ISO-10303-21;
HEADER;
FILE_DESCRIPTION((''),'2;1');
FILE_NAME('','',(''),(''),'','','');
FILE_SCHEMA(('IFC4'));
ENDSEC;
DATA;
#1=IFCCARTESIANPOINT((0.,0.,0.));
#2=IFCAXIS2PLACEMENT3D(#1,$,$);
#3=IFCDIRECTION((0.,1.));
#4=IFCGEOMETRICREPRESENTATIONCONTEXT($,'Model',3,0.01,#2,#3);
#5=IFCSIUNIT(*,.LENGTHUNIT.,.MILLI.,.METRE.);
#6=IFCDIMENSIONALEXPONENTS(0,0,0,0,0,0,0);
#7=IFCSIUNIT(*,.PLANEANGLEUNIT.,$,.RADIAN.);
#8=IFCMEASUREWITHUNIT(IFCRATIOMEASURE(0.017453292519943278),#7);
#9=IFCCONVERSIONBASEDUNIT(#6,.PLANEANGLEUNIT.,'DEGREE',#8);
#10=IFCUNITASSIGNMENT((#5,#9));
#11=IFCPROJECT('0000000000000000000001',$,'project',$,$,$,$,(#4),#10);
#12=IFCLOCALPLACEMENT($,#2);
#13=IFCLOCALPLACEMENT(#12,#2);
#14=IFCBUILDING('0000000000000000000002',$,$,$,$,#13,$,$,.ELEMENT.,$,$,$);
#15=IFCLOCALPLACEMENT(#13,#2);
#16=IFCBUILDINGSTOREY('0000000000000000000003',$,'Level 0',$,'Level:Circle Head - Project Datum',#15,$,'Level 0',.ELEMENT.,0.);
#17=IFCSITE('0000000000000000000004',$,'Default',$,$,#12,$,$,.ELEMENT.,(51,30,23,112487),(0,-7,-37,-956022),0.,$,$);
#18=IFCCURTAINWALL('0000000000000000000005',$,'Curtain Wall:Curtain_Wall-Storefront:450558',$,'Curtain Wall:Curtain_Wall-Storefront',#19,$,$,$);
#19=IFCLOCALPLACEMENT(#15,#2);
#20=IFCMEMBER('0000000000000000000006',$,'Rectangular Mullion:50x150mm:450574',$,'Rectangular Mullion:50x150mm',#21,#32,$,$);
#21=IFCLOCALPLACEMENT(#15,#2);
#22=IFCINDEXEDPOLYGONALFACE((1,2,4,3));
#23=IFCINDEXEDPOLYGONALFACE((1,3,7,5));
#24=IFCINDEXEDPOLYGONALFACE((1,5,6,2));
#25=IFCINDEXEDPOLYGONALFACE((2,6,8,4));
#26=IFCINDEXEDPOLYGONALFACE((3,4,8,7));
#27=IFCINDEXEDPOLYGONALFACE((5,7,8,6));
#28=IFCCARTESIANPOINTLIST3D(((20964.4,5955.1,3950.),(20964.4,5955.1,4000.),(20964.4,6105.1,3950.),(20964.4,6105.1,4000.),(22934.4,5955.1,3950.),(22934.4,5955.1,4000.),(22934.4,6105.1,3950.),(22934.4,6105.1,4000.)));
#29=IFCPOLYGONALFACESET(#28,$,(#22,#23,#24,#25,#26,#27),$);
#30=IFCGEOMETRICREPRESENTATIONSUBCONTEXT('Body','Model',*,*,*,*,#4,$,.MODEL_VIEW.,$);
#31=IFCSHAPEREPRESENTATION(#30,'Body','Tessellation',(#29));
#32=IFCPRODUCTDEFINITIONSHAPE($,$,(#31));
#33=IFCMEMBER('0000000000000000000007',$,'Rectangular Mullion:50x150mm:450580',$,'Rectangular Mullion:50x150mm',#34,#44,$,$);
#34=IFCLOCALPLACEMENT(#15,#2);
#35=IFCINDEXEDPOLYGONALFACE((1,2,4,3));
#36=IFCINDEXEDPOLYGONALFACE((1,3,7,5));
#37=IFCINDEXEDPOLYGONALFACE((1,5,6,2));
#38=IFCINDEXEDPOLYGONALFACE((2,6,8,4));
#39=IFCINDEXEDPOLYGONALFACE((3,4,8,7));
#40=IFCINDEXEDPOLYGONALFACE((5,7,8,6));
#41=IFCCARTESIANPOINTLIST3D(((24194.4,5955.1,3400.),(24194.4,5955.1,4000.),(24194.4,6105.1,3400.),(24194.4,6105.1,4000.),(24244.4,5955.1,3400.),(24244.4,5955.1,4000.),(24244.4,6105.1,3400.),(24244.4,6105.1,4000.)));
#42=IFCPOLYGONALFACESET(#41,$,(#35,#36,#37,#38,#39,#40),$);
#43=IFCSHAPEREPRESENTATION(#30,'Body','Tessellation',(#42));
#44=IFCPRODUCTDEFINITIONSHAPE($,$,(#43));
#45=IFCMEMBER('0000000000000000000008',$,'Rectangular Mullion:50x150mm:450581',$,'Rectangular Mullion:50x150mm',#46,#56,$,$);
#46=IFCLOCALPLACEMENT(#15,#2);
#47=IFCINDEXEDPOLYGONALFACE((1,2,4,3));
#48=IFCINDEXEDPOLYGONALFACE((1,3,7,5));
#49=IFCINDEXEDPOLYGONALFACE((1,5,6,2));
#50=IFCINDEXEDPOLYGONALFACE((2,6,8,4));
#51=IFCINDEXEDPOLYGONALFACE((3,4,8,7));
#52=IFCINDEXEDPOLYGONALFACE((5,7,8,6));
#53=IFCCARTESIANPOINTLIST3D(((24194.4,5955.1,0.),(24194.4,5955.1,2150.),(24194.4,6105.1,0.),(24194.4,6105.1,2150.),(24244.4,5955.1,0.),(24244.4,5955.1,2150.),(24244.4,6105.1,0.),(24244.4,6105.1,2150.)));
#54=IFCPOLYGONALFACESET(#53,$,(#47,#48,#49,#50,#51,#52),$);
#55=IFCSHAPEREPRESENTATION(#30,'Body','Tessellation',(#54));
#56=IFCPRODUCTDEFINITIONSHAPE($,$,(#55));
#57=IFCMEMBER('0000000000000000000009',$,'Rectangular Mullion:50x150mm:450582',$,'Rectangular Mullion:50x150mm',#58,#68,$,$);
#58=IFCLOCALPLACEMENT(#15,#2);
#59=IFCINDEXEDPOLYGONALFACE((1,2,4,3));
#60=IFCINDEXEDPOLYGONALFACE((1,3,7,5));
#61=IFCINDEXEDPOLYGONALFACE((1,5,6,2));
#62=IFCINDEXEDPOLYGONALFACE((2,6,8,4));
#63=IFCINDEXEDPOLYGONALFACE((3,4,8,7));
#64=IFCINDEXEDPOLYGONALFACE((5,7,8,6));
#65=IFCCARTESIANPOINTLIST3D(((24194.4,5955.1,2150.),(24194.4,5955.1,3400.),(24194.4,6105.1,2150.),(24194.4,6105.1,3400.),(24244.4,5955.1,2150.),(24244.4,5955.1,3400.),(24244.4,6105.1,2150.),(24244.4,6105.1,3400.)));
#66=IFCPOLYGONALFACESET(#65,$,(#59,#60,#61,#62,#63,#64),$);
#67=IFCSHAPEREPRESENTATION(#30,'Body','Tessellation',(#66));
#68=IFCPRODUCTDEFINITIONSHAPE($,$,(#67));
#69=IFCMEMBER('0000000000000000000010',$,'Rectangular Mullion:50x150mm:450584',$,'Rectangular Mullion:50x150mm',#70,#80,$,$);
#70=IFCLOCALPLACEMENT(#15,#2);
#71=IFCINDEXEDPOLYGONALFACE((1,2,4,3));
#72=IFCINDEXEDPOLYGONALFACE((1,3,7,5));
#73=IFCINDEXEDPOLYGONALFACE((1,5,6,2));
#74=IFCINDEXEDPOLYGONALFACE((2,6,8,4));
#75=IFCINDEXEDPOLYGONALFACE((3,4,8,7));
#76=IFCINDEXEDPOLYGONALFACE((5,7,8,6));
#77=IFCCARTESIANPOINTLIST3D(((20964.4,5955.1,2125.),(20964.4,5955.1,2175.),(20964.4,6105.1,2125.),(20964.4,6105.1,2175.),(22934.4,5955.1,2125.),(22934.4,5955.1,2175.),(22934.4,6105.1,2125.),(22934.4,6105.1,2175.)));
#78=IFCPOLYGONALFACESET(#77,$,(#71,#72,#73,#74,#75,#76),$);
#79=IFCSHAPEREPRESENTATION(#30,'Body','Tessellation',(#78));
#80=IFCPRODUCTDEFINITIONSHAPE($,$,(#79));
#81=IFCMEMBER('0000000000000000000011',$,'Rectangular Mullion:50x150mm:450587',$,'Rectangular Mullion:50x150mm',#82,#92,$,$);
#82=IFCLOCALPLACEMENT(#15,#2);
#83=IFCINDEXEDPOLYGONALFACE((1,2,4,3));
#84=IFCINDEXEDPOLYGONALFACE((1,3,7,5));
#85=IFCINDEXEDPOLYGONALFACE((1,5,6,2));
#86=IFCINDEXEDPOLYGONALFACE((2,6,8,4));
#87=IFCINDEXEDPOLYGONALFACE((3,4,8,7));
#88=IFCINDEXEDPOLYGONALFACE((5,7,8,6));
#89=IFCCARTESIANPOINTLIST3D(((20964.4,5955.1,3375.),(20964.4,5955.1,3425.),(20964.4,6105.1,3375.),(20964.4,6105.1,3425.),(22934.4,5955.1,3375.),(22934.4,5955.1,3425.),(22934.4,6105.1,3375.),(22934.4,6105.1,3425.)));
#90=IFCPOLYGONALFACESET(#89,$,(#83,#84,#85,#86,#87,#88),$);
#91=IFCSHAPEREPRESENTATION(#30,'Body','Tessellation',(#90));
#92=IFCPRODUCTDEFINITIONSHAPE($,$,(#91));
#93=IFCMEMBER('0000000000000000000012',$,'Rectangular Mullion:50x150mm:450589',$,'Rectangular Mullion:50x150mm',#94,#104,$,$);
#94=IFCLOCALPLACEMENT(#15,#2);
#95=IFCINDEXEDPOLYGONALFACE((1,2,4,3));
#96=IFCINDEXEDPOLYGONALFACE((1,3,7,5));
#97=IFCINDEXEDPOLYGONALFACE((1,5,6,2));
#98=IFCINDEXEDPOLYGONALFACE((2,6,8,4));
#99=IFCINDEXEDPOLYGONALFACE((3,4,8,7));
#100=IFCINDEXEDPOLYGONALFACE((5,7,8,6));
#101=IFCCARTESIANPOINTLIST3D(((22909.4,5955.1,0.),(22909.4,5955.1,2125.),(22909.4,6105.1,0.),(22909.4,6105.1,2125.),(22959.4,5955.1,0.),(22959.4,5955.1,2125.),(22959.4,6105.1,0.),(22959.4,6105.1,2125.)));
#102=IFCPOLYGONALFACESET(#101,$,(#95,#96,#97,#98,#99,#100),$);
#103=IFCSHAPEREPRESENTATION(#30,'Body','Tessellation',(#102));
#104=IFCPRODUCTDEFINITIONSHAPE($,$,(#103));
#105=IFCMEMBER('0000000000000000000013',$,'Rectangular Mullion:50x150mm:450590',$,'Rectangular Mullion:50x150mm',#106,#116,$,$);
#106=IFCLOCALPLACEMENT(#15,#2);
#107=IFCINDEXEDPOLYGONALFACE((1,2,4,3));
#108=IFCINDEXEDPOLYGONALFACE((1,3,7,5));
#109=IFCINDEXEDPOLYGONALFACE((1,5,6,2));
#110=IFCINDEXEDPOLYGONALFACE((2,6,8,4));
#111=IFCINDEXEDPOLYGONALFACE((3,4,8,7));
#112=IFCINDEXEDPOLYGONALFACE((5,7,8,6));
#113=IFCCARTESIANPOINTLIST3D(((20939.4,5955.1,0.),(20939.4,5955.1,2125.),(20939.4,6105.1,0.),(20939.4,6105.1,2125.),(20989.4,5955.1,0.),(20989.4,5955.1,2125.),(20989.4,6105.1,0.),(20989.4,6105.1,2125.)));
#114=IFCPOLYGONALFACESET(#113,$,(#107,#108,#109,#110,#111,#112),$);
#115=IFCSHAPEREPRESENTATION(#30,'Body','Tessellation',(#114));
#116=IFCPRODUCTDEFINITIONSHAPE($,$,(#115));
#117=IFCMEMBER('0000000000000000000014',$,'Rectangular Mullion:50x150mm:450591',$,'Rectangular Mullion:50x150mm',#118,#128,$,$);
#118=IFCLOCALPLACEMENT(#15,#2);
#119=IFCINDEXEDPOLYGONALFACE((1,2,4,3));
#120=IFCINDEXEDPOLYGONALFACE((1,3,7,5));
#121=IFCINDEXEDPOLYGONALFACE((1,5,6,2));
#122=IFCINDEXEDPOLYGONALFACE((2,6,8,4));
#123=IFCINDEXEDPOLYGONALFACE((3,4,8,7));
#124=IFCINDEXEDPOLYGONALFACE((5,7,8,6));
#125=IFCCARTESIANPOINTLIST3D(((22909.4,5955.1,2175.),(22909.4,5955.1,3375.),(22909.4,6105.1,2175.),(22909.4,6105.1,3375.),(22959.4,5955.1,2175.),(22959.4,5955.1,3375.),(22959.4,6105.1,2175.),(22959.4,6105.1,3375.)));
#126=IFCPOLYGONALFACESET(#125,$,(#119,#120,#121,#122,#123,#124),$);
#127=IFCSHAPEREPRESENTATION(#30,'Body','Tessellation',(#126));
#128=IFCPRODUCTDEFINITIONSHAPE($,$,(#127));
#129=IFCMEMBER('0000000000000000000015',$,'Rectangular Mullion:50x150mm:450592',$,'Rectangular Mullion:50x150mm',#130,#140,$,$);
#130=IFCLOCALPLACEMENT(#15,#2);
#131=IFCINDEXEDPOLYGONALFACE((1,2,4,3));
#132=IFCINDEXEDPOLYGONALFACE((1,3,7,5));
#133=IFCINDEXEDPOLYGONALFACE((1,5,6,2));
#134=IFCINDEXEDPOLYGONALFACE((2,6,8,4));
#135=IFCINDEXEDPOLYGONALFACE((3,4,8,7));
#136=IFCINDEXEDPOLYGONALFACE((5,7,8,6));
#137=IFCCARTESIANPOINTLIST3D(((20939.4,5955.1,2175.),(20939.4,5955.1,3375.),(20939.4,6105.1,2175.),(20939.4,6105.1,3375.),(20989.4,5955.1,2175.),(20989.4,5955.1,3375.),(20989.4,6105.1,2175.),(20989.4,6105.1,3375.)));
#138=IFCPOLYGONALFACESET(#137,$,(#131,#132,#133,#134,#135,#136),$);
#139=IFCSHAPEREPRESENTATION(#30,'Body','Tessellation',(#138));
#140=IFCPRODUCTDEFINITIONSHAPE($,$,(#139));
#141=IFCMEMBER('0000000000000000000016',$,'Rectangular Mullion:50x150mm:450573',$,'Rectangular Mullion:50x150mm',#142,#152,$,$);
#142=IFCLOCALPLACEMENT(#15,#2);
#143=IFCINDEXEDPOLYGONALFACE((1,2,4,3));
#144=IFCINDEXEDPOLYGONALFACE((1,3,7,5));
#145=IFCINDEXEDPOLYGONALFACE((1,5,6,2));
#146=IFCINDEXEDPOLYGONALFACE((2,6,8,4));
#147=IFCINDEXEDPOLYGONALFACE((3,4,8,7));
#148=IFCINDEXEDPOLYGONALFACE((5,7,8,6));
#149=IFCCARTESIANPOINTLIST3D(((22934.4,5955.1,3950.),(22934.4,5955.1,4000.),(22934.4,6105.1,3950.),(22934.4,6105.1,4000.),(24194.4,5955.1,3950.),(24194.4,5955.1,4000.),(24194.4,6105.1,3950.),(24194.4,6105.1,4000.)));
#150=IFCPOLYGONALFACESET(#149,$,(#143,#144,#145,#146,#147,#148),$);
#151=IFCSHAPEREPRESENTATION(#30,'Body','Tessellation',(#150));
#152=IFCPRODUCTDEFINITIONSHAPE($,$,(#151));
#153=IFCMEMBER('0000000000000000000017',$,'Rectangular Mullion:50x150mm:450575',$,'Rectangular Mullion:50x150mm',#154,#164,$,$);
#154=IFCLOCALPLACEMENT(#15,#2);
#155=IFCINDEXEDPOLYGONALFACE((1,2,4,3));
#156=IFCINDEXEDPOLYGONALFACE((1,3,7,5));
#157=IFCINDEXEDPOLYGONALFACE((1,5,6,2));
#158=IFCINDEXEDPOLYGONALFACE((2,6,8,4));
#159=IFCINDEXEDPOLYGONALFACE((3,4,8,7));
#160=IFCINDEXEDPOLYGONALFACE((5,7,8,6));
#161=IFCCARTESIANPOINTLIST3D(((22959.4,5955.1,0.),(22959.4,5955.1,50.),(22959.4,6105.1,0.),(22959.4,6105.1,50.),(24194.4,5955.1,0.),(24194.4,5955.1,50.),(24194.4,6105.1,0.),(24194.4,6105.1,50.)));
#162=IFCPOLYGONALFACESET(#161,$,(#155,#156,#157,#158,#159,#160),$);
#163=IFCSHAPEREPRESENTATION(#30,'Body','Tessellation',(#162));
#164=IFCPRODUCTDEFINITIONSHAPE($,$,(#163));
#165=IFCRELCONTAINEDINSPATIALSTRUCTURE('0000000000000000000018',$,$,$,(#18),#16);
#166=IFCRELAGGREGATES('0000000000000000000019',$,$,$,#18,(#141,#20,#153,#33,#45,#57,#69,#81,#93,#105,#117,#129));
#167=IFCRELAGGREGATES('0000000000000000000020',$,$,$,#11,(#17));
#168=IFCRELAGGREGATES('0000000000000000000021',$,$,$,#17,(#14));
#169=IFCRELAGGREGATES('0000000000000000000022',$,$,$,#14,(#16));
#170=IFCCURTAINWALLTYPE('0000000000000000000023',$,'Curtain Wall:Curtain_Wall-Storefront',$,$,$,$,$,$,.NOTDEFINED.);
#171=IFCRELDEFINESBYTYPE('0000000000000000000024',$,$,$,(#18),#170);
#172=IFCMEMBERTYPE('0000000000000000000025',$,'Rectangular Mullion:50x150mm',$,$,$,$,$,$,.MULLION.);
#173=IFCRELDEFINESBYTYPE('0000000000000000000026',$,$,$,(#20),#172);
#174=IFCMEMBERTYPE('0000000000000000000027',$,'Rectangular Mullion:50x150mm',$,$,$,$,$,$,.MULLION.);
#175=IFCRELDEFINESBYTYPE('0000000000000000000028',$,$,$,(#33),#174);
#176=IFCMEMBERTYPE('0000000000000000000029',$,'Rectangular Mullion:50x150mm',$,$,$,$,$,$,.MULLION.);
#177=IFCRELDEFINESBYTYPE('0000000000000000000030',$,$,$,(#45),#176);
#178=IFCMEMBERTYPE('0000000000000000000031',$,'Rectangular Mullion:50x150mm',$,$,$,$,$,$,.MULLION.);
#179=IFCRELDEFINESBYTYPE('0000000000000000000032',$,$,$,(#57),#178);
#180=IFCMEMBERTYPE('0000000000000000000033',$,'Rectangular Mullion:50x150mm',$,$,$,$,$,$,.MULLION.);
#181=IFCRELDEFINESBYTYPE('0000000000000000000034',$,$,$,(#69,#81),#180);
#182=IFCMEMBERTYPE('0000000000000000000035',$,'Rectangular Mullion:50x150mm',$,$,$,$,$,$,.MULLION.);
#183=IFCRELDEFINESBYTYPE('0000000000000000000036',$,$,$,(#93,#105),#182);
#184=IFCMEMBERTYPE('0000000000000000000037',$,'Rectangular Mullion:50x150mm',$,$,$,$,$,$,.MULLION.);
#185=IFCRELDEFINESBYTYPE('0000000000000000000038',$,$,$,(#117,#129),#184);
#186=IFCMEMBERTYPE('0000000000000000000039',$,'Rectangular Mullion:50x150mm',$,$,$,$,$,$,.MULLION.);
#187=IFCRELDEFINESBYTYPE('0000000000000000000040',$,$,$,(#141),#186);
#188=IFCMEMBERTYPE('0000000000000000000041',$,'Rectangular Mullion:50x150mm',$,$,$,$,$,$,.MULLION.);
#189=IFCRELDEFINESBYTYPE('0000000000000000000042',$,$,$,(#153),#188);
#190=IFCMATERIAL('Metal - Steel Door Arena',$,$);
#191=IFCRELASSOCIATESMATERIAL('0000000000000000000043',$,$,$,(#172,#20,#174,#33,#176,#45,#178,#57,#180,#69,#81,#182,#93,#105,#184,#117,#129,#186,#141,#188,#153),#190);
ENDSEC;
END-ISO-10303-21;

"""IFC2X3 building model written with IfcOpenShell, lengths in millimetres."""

from ifc_helpers import new_model, entity, si_unit, converted_unit, direction, frame, origin, origin_2d_with_axis, place, context, subcontext, project, spatial, rectangle, extrude, source, transform, mapped, material, type_object, type_shapes, element, aggregate, save


model = new_model("IFC2X3")

# Units and contexts
model_context = context("Model", 3, precision=0.01, world=origin(), true_north=direction((0.0, 1.0)))
body_context = subcontext(model_context, "Body", "Model", "MODEL_VIEW")
ifc_project = project(units=[si_unit("LENGTHUNIT", "METRE", prefix="MILLI"), converted_unit("PLANEANGLEUNIT", "DEGREE", entity("IfcRatioMeasure", 0.017453292519943278), si_unit("PLANEANGLEUNIT", "RADIAN"), dimensions=[0, 0, 0, 0, 0, 0, 0])], contexts=[model_context])

# Site, building, storey
site_placement = place(None, origin())
site = spatial("IfcSite", under=ifc_project, at=site_placement, Name="Default", CompositionType="ELEMENT", RefLatitude=(51, 30, 23, 112487), RefLongitude=(0, -7, -37, -956022), RefElevation=0.0)
building_placement = place(site_placement, origin())
building = spatial("IfcBuilding", under=site, at=building_placement, CompositionType="ELEMENT")
storey_placement = place(building_placement, origin())
storey = spatial("IfcBuildingStorey", under=building, at=storey_placement, Name="Level 0", ObjectType="Level:Circle Head - Project Datum", LongName="Level 0", CompositionType="ELEMENT", Elevation=0.0)

# Curtain wall, members
curtain_wall_type = type_object("IfcCurtainWallType", Name="Curtain Wall:Curtain_Wall-Storefront", PredefinedType="NOTDEFINED")
curtain_wall_placement = place(storey_placement, origin())
curtain_wall = element("IfcCurtainWall", 1, at=curtain_wall_placement, inside=storey, type_object=curtain_wall_type, Name="Curtain Wall:Curtain_Wall-Storefront:450558", ObjectType="Curtain Wall:Curtain_Wall-Storefront")
ifc_material_1 = material(Name="Metal - Steel Door Arena")
member_type_1 = type_object("IfcMemberType", Name="Rectangular Mullion:50x150mm", PredefinedType="MULLION", material=ifc_material_1)
shared_shape_1 = source(origin(), body_context, "Body", "SweptSolid", [
    extrude(rectangle(XDim=150.0, YDim=50.0, at=origin_2d_with_axis()), frame((-25.0, 0.0, -1970.0), z_axis=(0.0, 0.0, 1.0), x_axis=(0.0, -1.0, 0.0)), (0.0, 0.0, 1.0), 1970.0),
])
type_shapes(member_type_1, [shared_shape_1])
member_1_placement = place(curtain_wall_placement, frame((20964.4, 6030.1, 4000.0), z_axis=(-1.0, 0.0, 0.0), x_axis=(0.0, 0.0, 1.0)))
member_1 = element("IfcMember", 2, at=member_1_placement, type_object=member_type_1, material=ifc_material_1, Name="Rectangular Mullion:50x150mm:450574", ObjectType="Rectangular Mullion:50x150mm", context=body_context, shape_type="MappedRepresentation", body=[
    mapped(shared_shape_1, transform((0.0, 0.0, 0.0), scale=1.0)),
])
member_type_2 = type_object("IfcMemberType", Name="Rectangular Mullion:50x150mm", PredefinedType="MULLION", material=ifc_material_1)
shared_shape_2 = source(origin(), body_context, "Body", "SweptSolid", [
    extrude(rectangle(XDim=150.0, YDim=50.0, at=origin_2d_with_axis()), frame((-25.0, 0.0, -600.0), z_axis=(0.0, 0.0, 1.0), x_axis=(0.0, -1.0, 0.0)), (0.0, 0.0, 1.0), 600.0),
])
type_shapes(member_type_2, [shared_shape_2])
member_2_placement = place(curtain_wall_placement, frame((24244.4, 6030.1, 4000.0)))
member_2 = element("IfcMember", 3, at=member_2_placement, type_object=member_type_2, material=ifc_material_1, Name="Rectangular Mullion:50x150mm:450580", ObjectType="Rectangular Mullion:50x150mm", context=body_context, shape_type="MappedRepresentation", body=[
    mapped(shared_shape_2, transform((0.0, 0.0, 0.0), scale=1.0)),
])
member_type_3 = type_object("IfcMemberType", Name="Rectangular Mullion:50x150mm", PredefinedType="MULLION", material=ifc_material_1)
shared_shape_3 = source(origin(), body_context, "Body", "SweptSolid", [
    extrude(rectangle(XDim=150.0, YDim=50.0, at=origin_2d_with_axis()), frame((-25.0, 0.0, -2150.0), z_axis=(0.0, 0.0, 1.0), x_axis=(0.0, -1.0, 0.0)), (0.0, 0.0, 1.0), 2150.0),
])
type_shapes(member_type_3, [shared_shape_3])
member_3_placement = place(curtain_wall_placement, frame((24244.4, 6030.1, 2150.0)))
member_3 = element("IfcMember", 4, at=member_3_placement, type_object=member_type_3, material=ifc_material_1, Name="Rectangular Mullion:50x150mm:450581", ObjectType="Rectangular Mullion:50x150mm", context=body_context, shape_type="MappedRepresentation", body=[
    mapped(shared_shape_3, transform((0.0, 0.0, 0.0), scale=1.0)),
])
member_type_4 = type_object("IfcMemberType", Name="Rectangular Mullion:50x150mm", PredefinedType="MULLION", material=ifc_material_1)
shared_shape_4 = source(origin(), body_context, "Body", "SweptSolid", [
    extrude(rectangle(XDim=150.0, YDim=50.0, at=origin_2d_with_axis()), frame((-25.0, 0.0, -1250.0), z_axis=(0.0, 0.0, 1.0), x_axis=(0.0, -1.0, 0.0)), (0.0, 0.0, 1.0), 1250.0),
])
type_shapes(member_type_4, [shared_shape_4])
member_4_placement = place(curtain_wall_placement, frame((24244.4, 6030.1, 3400.0)))
member_4 = element("IfcMember", 5, at=member_4_placement, type_object=member_type_4, material=ifc_material_1, Name="Rectangular Mullion:50x150mm:450582", ObjectType="Rectangular Mullion:50x150mm", context=body_context, shape_type="MappedRepresentation", body=[
    mapped(shared_shape_4, transform((0.0, 0.0, 0.0), scale=1.0)),
])
member_type_5 = type_object("IfcMemberType", Name="Rectangular Mullion:50x150mm", PredefinedType="MULLION", material=ifc_material_1)
shared_shape_5 = source(origin(), body_context, "Body", "SweptSolid", [
    extrude(rectangle(XDim=150.0, YDim=50.0, at=origin_2d_with_axis()), frame((0.0, 0.0, -1970.0), z_axis=(0.0, 0.0, 1.0), x_axis=(0.0, -1.0, 0.0)), (0.0, 0.0, 1.0), 1970.0),
])
type_shapes(member_type_5, [shared_shape_5])
member_5_placement = place(curtain_wall_placement, frame((20964.4, 6030.1, 2150.0), z_axis=(-1.0, 0.0, 0.0), x_axis=(0.0, 0.0, 1.0)))
member_5 = element("IfcMember", 6, at=member_5_placement, type_object=member_type_5, material=ifc_material_1, Name="Rectangular Mullion:50x150mm:450584", ObjectType="Rectangular Mullion:50x150mm", context=body_context, shape_type="MappedRepresentation", body=[
    mapped(shared_shape_5, transform((0.0, 0.0, 0.0), scale=1.0)),
])
member_6_placement = place(curtain_wall_placement, frame((20964.4, 6030.1, 3400.0), z_axis=(-1.0, 0.0, 0.0), x_axis=(0.0, 0.0, 1.0)))
member_6 = element("IfcMember", 7, at=member_6_placement, type_object=member_type_5, material=ifc_material_1, Name="Rectangular Mullion:50x150mm:450587", ObjectType="Rectangular Mullion:50x150mm", context=body_context, shape_type="MappedRepresentation", body=[
    mapped(shared_shape_5, transform((0.0, 0.0, 0.0), scale=1.0)),
])
member_type_6 = type_object("IfcMemberType", Name="Rectangular Mullion:50x150mm", PredefinedType="MULLION", material=ifc_material_1)
shared_shape_6 = source(origin(), body_context, "Body", "SweptSolid", [
    extrude(rectangle(XDim=150.0, YDim=50.0, at=origin_2d_with_axis()), frame((0.0, 0.0, -2125.0), z_axis=(0.0, 0.0, 1.0), x_axis=(0.0, -1.0, 0.0)), (0.0, 0.0, 1.0), 2125.0),
])
type_shapes(member_type_6, [shared_shape_6])
member_7_placement = place(curtain_wall_placement, frame((22934.4, 6030.1, 0.0), z_axis=(0.0, 0.0, -1.0), x_axis=(-1.0, 0.0, 0.0)))
member_7 = element("IfcMember", 8, at=member_7_placement, type_object=member_type_6, material=ifc_material_1, Name="Rectangular Mullion:50x150mm:450589", ObjectType="Rectangular Mullion:50x150mm", context=body_context, shape_type="MappedRepresentation", body=[
    mapped(shared_shape_6, transform((0.0, 0.0, 0.0), scale=1.0)),
])
member_8_placement = place(curtain_wall_placement, frame((20964.4, 6030.1, 0.0), z_axis=(0.0, 0.0, -1.0), x_axis=(-1.0, 0.0, 0.0)))
member_8 = element("IfcMember", 9, at=member_8_placement, type_object=member_type_6, material=ifc_material_1, Name="Rectangular Mullion:50x150mm:450590", ObjectType="Rectangular Mullion:50x150mm", context=body_context, shape_type="MappedRepresentation", body=[
    mapped(shared_shape_6, transform((0.0, 0.0, 0.0), scale=1.0)),
])
member_type_7 = type_object("IfcMemberType", Name="Rectangular Mullion:50x150mm", PredefinedType="MULLION", material=ifc_material_1)
shared_shape_7 = source(origin(), body_context, "Body", "SweptSolid", [
    extrude(rectangle(XDim=150.0, YDim=50.0, at=origin_2d_with_axis()), frame((0.0, 0.0, -1200.0), z_axis=(0.0, 0.0, 1.0), x_axis=(0.0, -1.0, 0.0)), (0.0, 0.0, 1.0), 1200.0),
])
type_shapes(member_type_7, [shared_shape_7])
member_9_placement = place(curtain_wall_placement, frame((22934.4, 6030.1, 2175.0), z_axis=(0.0, 0.0, -1.0), x_axis=(-1.0, 0.0, 0.0)))
member_9 = element("IfcMember", 10, at=member_9_placement, type_object=member_type_7, material=ifc_material_1, Name="Rectangular Mullion:50x150mm:450591", ObjectType="Rectangular Mullion:50x150mm", context=body_context, shape_type="MappedRepresentation", body=[
    mapped(shared_shape_7, transform((0.0, 0.0, 0.0), scale=1.0)),
])
member_10_placement = place(curtain_wall_placement, frame((20964.4, 6030.1, 2175.0), z_axis=(0.0, 0.0, -1.0), x_axis=(-1.0, 0.0, 0.0)))
member_10 = element("IfcMember", 11, at=member_10_placement, type_object=member_type_7, material=ifc_material_1, Name="Rectangular Mullion:50x150mm:450592", ObjectType="Rectangular Mullion:50x150mm", context=body_context, shape_type="MappedRepresentation", body=[
    mapped(shared_shape_7, transform((0.0, 0.0, 0.0), scale=1.0)),
])
member_type_8 = type_object("IfcMemberType", Name="Rectangular Mullion:50x150mm", PredefinedType="MULLION", material=ifc_material_1)
shared_shape_8 = source(origin(), body_context, "Body", "SweptSolid", [
    extrude(rectangle(XDim=150.0, YDim=50.0, at=origin_2d_with_axis()), frame((-25.0, 0.0, -1260.0), z_axis=(0.0, 0.0, 1.0), x_axis=(0.0, -1.0, 0.0)), (0.0, 0.0, 1.0), 1260.0),
])
type_shapes(member_type_8, [shared_shape_8])
member_11_placement = place(curtain_wall_placement, frame((22934.4, 6030.1, 4000.0), z_axis=(-1.0, 0.0, 0.0), x_axis=(0.0, 0.0, 1.0)))
member_11 = element("IfcMember", 12, at=member_11_placement, type_object=member_type_8, material=ifc_material_1, Name="Rectangular Mullion:50x150mm:450573", ObjectType="Rectangular Mullion:50x150mm", context=body_context, shape_type="MappedRepresentation", body=[
    mapped(shared_shape_8, transform((0.0, 0.0, 0.0), scale=1.0)),
])
member_type_9 = type_object("IfcMemberType", Name="Rectangular Mullion:50x150mm", PredefinedType="MULLION", material=ifc_material_1)
shared_shape_9 = source(origin(), body_context, "Body", "SweptSolid", [
    extrude(rectangle(XDim=150.0, YDim=50.0, at=origin_2d_with_axis()), frame((-25.0, 0.0, -1235.0), z_axis=(0.0, 0.0, 1.0), x_axis=(0.0, -1.0, 0.0)), (0.0, 0.0, 1.0), 1235.0),
])
type_shapes(member_type_9, [shared_shape_9])
member_12_placement = place(curtain_wall_placement, frame((24194.4, 6030.1, 0.0), z_axis=(1.0, 0.0, 0.0), x_axis=(0.0, 0.0, -1.0)))
member_12 = element("IfcMember", 13, at=member_12_placement, type_object=member_type_9, material=ifc_material_1, Name="Rectangular Mullion:50x150mm:450575", ObjectType="Rectangular Mullion:50x150mm", context=body_context, shape_type="MappedRepresentation", body=[
    mapped(shared_shape_9, transform((0.0, 0.0, 0.0), scale=1.0)),
])
aggregate(curtain_wall, [member_11, member_1, member_12, member_2, member_3, member_4, member_5, member_6, member_7, member_8, member_9, member_10])

save(model, "model.ifc")
